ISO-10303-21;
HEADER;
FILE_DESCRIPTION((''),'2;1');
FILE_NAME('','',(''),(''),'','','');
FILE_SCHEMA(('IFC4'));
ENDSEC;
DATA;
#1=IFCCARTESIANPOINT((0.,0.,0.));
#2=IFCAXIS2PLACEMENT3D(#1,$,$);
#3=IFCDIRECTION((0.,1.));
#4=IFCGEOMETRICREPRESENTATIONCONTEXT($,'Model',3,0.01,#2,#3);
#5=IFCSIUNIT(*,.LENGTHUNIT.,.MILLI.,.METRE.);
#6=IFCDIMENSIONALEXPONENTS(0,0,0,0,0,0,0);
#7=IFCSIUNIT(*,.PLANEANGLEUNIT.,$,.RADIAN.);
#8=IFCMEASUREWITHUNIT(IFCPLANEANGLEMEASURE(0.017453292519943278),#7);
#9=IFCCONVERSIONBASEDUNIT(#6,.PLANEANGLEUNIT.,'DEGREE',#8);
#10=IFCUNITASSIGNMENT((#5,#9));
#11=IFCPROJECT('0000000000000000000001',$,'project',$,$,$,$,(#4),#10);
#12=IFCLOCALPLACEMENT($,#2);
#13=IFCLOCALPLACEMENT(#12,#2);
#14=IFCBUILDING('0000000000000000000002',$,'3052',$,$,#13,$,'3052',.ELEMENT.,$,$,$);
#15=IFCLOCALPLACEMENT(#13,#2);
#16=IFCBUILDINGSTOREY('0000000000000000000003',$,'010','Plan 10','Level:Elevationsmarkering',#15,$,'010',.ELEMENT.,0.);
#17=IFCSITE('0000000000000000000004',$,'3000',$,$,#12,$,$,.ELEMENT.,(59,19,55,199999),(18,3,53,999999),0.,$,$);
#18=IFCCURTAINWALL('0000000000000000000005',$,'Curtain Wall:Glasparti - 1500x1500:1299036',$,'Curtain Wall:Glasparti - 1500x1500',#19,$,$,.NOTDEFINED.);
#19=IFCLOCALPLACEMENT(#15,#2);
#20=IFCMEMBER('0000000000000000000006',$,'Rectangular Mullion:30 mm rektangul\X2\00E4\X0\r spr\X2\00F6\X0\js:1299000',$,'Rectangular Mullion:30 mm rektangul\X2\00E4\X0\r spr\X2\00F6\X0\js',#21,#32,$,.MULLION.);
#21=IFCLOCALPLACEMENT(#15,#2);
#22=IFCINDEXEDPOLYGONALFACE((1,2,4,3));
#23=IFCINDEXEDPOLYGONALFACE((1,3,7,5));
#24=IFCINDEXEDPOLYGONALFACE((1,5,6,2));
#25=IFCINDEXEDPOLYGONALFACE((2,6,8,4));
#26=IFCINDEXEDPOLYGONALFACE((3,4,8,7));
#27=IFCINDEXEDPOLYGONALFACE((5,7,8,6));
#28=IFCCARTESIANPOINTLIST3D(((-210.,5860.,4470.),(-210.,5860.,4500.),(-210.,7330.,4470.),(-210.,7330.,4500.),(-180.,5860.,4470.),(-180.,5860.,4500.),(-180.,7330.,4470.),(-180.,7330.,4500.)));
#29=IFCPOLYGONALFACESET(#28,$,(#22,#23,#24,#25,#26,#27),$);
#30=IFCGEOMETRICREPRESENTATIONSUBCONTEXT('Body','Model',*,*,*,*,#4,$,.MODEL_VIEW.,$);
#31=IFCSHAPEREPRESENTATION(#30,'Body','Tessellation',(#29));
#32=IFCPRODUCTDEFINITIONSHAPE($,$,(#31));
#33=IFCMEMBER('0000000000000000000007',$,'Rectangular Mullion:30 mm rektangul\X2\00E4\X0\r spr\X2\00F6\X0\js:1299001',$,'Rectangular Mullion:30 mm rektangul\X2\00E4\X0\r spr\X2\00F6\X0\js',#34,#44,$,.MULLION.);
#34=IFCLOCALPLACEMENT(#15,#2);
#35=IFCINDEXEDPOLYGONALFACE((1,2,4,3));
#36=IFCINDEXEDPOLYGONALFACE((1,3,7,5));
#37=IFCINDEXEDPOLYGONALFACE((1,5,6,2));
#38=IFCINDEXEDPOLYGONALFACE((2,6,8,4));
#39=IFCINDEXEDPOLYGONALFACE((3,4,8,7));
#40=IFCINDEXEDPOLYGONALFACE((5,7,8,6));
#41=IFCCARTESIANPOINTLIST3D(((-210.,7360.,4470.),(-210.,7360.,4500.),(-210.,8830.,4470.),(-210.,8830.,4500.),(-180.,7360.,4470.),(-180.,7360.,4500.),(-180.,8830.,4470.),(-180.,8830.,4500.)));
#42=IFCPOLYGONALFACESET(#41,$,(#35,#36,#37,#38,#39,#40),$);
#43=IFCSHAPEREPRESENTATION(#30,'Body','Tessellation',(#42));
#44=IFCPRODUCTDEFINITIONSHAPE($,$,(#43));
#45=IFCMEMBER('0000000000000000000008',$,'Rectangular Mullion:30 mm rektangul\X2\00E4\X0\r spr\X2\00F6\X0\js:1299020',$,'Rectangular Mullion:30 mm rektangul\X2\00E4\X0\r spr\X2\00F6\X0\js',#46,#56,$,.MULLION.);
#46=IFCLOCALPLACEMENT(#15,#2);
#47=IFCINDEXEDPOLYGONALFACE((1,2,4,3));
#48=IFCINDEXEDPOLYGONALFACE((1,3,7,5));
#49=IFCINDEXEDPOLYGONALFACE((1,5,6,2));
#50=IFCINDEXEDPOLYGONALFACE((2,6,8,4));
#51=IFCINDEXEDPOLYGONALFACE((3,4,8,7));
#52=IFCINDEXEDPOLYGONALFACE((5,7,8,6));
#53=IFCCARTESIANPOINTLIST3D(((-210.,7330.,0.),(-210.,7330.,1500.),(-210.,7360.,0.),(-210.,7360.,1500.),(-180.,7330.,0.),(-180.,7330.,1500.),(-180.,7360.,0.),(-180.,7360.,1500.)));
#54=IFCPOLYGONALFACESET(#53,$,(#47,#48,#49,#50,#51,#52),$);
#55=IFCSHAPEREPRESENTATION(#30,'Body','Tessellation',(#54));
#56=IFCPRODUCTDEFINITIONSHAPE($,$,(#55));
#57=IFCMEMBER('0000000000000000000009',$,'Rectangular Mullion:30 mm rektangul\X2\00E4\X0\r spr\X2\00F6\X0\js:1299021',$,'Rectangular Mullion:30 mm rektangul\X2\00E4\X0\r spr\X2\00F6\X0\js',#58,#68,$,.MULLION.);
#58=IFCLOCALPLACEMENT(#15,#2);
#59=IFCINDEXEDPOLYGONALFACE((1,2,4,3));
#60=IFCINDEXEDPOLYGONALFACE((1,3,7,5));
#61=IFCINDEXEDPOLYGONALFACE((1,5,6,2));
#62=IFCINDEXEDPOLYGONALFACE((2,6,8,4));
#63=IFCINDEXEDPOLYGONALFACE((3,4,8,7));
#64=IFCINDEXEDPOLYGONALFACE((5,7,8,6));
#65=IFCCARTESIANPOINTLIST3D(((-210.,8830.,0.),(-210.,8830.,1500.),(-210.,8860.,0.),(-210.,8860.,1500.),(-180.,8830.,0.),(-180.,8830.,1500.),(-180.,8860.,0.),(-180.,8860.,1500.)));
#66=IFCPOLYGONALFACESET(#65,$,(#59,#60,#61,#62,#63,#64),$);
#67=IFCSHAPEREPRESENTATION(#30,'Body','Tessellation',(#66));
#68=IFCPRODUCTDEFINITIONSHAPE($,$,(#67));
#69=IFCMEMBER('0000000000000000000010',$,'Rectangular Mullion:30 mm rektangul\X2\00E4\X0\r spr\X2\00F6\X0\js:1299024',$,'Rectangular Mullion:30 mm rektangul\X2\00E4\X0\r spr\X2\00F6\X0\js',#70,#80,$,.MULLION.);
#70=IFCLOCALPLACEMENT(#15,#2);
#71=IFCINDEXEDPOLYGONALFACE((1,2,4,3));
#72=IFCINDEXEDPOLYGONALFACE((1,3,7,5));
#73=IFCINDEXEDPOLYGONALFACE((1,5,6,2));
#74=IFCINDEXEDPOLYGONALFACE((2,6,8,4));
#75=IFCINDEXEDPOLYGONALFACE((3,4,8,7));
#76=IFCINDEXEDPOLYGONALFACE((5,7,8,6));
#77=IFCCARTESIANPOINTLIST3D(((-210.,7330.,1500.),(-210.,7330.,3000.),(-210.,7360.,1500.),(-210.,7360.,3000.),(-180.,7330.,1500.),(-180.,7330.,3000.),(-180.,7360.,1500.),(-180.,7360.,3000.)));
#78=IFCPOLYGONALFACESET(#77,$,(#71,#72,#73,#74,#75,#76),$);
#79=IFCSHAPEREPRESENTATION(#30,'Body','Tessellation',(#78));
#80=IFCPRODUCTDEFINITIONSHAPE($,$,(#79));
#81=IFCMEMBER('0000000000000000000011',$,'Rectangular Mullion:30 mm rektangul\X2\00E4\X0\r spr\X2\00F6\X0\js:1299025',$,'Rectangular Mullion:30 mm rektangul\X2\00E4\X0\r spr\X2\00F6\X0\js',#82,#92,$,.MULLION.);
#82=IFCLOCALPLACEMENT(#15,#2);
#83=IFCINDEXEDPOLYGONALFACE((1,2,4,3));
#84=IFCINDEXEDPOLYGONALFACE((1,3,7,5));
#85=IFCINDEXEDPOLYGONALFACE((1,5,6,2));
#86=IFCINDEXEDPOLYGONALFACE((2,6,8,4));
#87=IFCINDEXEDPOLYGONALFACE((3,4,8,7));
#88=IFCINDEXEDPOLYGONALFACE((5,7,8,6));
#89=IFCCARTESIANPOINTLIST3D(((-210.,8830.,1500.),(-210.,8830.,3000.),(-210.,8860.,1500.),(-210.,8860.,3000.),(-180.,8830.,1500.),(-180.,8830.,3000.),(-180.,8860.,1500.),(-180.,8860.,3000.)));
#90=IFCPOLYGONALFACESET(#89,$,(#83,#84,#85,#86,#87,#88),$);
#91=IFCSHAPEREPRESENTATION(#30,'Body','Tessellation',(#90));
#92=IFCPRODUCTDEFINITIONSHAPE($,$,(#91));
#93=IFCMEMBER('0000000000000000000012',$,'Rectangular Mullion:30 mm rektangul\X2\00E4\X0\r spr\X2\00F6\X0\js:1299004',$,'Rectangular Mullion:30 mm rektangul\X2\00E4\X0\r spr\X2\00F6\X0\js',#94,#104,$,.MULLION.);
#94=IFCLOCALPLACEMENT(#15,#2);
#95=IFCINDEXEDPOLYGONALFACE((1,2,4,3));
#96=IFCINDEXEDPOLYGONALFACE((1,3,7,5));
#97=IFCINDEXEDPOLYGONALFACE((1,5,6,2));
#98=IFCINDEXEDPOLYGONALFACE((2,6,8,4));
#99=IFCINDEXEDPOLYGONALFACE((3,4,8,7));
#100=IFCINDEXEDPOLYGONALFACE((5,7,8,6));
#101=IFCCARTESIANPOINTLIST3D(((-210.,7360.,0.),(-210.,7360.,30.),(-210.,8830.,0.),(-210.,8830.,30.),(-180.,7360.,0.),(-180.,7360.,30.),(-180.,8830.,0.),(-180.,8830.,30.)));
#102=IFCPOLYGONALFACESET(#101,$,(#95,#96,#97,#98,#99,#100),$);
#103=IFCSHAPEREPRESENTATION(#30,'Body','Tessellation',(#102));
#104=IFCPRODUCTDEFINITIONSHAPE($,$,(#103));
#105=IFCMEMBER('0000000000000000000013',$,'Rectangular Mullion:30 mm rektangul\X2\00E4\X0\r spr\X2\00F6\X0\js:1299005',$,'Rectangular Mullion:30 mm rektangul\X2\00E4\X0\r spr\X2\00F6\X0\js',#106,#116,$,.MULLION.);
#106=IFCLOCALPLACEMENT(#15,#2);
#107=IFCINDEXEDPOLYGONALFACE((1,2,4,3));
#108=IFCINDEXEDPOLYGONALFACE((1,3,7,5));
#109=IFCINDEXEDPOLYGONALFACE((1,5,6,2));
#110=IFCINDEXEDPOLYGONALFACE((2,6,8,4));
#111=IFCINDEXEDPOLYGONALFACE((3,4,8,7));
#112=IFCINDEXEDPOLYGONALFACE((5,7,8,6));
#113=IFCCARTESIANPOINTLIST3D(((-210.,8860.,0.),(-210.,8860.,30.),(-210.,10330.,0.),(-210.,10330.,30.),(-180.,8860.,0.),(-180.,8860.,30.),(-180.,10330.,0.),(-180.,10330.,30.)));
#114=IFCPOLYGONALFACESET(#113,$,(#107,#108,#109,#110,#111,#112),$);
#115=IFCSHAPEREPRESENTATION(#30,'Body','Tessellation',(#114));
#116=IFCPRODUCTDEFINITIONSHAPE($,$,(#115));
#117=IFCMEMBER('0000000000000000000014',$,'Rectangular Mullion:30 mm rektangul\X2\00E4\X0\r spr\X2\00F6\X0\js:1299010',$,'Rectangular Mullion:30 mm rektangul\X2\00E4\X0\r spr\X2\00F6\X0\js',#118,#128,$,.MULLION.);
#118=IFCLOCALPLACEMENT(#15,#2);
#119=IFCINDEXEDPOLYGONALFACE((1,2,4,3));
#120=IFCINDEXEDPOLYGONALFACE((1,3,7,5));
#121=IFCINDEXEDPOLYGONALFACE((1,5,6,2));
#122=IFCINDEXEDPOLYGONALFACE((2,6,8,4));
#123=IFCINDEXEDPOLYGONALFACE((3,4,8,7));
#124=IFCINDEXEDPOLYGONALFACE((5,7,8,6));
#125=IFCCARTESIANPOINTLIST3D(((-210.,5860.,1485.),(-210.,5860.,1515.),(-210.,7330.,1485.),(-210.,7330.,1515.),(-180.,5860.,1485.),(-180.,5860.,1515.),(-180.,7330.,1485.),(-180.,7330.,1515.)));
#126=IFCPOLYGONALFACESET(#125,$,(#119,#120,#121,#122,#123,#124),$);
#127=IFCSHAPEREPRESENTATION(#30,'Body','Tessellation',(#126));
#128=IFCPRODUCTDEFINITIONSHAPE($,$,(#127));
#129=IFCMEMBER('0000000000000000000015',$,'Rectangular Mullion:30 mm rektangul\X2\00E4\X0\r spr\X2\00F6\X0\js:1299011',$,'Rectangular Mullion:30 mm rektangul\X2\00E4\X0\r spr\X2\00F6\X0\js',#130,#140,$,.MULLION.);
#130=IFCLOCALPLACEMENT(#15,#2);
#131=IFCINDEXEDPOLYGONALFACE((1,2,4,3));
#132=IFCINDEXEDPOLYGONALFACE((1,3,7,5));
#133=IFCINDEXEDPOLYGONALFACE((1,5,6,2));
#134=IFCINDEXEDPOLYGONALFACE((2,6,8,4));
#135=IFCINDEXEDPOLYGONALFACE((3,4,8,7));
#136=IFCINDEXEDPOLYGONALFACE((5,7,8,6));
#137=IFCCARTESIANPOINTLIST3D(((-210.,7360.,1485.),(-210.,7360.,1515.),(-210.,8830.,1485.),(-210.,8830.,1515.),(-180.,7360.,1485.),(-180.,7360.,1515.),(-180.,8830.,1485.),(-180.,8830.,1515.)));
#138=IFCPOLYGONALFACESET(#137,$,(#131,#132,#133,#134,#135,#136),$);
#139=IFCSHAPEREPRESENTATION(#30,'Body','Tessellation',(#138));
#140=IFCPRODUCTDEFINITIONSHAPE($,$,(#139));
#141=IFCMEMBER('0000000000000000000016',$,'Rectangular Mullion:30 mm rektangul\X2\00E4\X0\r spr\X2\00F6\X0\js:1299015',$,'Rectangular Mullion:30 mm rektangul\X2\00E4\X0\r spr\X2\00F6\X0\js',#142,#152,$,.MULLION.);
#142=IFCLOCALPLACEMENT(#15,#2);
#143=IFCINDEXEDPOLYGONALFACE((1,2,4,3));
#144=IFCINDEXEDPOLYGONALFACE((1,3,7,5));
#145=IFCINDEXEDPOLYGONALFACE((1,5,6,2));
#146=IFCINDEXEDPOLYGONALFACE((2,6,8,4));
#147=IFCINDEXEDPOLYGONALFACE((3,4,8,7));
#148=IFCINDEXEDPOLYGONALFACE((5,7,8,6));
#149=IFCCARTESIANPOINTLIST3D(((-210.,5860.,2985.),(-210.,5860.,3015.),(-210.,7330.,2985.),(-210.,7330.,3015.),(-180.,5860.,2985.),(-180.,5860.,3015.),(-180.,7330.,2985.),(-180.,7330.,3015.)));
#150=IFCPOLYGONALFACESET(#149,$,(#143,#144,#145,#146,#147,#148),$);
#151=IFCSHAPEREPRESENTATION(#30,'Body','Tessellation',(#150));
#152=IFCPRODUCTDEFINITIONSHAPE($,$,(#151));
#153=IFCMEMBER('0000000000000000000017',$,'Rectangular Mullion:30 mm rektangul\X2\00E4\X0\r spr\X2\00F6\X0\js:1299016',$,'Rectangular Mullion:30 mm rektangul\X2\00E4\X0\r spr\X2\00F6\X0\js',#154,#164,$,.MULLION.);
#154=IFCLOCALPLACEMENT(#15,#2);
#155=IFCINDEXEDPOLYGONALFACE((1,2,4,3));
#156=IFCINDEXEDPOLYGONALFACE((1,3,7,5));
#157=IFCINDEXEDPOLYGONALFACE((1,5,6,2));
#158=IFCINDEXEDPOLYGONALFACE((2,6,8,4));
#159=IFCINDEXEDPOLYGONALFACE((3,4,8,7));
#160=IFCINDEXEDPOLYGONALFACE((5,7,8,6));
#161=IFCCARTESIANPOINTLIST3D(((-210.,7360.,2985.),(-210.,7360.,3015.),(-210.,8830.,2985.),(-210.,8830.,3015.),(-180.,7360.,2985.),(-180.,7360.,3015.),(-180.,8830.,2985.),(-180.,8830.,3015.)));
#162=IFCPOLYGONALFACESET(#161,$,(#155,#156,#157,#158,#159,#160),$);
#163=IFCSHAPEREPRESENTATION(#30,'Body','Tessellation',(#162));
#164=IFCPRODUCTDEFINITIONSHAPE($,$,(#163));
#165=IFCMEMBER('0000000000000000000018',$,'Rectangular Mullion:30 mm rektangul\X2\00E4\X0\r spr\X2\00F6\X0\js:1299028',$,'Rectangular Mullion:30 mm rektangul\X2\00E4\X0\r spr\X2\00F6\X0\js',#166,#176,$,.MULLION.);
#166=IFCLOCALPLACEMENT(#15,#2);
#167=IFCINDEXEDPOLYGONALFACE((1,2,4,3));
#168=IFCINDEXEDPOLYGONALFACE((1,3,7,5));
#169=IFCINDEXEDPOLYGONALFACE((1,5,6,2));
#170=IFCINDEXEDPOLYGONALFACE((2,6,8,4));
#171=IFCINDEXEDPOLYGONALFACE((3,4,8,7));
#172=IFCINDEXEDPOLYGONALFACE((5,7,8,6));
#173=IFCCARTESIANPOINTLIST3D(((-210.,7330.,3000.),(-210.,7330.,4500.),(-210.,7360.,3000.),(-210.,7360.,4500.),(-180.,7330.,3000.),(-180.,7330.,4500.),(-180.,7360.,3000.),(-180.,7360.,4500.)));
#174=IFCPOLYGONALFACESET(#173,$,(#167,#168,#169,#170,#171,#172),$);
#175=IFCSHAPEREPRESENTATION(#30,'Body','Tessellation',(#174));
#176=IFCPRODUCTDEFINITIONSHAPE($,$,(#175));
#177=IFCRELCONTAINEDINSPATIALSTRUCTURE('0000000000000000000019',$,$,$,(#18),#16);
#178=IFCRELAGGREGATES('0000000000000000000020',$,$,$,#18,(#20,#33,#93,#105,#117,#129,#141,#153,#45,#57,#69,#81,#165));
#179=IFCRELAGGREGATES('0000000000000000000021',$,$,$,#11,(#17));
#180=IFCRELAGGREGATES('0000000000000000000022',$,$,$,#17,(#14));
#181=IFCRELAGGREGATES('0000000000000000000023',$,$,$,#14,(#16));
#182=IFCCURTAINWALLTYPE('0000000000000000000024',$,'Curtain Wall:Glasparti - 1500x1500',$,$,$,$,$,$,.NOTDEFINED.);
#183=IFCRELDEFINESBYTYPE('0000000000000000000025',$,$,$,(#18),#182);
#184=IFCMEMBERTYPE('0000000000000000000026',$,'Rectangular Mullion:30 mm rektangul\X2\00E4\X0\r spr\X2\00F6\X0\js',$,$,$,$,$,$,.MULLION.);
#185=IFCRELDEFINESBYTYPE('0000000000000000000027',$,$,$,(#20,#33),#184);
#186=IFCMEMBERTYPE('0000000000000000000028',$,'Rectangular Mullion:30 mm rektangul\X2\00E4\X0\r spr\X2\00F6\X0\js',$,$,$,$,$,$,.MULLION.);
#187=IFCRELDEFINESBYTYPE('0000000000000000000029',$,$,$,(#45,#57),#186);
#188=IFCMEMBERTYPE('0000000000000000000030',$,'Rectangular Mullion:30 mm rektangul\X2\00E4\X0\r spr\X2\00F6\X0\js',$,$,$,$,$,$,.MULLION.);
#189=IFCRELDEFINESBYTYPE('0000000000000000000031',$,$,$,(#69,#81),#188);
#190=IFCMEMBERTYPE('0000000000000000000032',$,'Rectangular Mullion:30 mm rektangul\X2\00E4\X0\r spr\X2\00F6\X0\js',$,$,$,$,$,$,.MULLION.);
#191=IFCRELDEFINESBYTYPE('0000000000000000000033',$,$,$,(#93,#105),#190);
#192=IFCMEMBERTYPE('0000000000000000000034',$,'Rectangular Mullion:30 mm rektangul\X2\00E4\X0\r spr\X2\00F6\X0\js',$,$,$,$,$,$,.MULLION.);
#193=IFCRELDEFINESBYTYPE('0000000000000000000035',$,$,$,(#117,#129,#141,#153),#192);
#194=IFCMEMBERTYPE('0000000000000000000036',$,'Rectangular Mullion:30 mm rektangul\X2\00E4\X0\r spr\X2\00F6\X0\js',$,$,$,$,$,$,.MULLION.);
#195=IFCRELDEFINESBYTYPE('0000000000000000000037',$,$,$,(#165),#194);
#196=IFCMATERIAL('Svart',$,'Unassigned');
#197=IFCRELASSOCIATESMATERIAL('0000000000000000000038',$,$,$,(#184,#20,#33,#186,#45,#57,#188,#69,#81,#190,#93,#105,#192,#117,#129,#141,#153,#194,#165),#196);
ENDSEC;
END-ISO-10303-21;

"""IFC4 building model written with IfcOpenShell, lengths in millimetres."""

from ifc_helpers import new_model, entity, si_unit, converted_unit, direction, frame, origin, place, context, subcontext, project, spatial, indexed_curve, outline, extrude, source, transform, mapped, material, type_object, type_shapes, element, aggregate, save


model = new_model("IFC4")

# Units and contexts
model_context = context("Model", 3, precision=0.01, world=origin(), true_north=direction((0.0, 1.0)))
body_context = subcontext(model_context, "Body", "Model", "MODEL_VIEW")
ifc_project = project(units=[si_unit("LENGTHUNIT", "METRE", prefix="MILLI"), converted_unit("PLANEANGLEUNIT", "DEGREE", entity("IfcPlaneAngleMeasure", 0.017453292519943278), si_unit("PLANEANGLEUNIT", "RADIAN"), dimensions=[0, 0, 0, 0, 0, 0, 0])], contexts=[model_context])

# Site, building, storey
site_placement = place(None, origin())
site = spatial("IfcSite", under=ifc_project, at=site_placement, Name="3000", CompositionType="ELEMENT", RefLatitude=(59, 19, 55, 199999), RefLongitude=(18, 3, 53, 999999), RefElevation=0.0)
building_placement = place(site_placement, origin())
building = spatial("IfcBuilding", under=site, at=building_placement, Name="3052", LongName="3052", CompositionType="ELEMENT")
storey_placement = place(building_placement, origin())
storey = spatial("IfcBuildingStorey", under=building, at=storey_placement, Name="010", Description="Plan 10", ObjectType="Level:Elevationsmarkering", LongName="010", CompositionType="ELEMENT", Elevation=0.0)

# Curtain wall, members
curtain_wall_type = type_object("IfcCurtainWallType", Name="Curtain Wall:Glasparti - 1500x1500", PredefinedType="NOTDEFINED")
curtain_wall_placement = place(storey_placement, origin())
curtain_wall = element("IfcCurtainWall", 1, at=curtain_wall_placement, inside=storey, type_object=curtain_wall_type, Name="Curtain Wall:Glasparti - 1500x1500:1299036", ObjectType="Curtain Wall:Glasparti - 1500x1500", PredefinedType="NOTDEFINED")
ifc_material_1 = material(Name="Svart", Category="Unassigned")
member_type_1 = type_object("IfcMemberType", Name="Rectangular Mullion:30 mm rektangulär spröjs", PredefinedType="MULLION", material=ifc_material_1)
shared_shape_1 = source(origin(), body_context, "Body", "SweptSolid", [
    extrude(outline(indexed_curve([(-15.0, -15.0), (15.0, -15.0), (15.0, 15.0), (-15.0, 15.0), (-15.0, -15.0)], self_intersect=False)), frame((-15.0, 0.0, -1470.0), z_axis=(0.0, 0.0, 1.0), x_axis=(-1.0, 0.0, 0.0)), (0.0, 0.0, 1.0), 1470.0),
])
type_shapes(member_type_1, [shared_shape_1])
member_1_placement = place(curtain_wall_placement, frame((-195.0, 7330.0, 4500.0), z_axis=(0.0, 1.0, 0.0), x_axis=(0.0, 0.0, 1.0)))
member_1 = element("IfcMember", 2, at=member_1_placement, type_object=member_type_1, material=ifc_material_1, Name="Rectangular Mullion:30 mm rektangulär spröjs:1299000", ObjectType="Rectangular Mullion:30 mm rektangulär spröjs", PredefinedType="MULLION", context=body_context, shape_type="MappedRepresentation", body=[
    mapped(shared_shape_1, transform((0.0, 0.0, 0.0), scale=1.0)),
])
member_2_placement = place(curtain_wall_placement, frame((-195.0, 8830.0, 4500.0), z_axis=(0.0, 1.0, 0.0), x_axis=(0.0, 0.0, 1.0)))
member_2 = element("IfcMember", 3, at=member_2_placement, type_object=member_type_1, material=ifc_material_1, Name="Rectangular Mullion:30 mm rektangulär spröjs:1299001", ObjectType="Rectangular Mullion:30 mm rektangulär spröjs", PredefinedType="MULLION", context=body_context, shape_type="MappedRepresentation", body=[
    mapped(shared_shape_1, transform((0.0, 0.0, 0.0), scale=1.0)),
])
member_type_2 = type_object("IfcMemberType", Name="Rectangular Mullion:30 mm rektangulär spröjs", PredefinedType="MULLION", material=ifc_material_1)
shared_shape_2 = source(origin(), body_context, "Body", "SweptSolid", [
    extrude(outline(indexed_curve([(-15.0, -15.0), (15.0, -15.0), (15.0, 15.0), (-15.0, 15.0), (-15.0, -15.0)], self_intersect=False)), frame((0.0, 0.0, -1500.0), z_axis=(0.0, 0.0, 1.0), x_axis=(-1.0, 0.0, 0.0)), (0.0, 0.0, 1.0), 1500.0),
])
type_shapes(member_type_2, [shared_shape_2])
member_3_placement = place(curtain_wall_placement, frame((-195.0, 7345.0, 0.0), z_axis=(0.0, 0.0, -1.0), x_axis=(0.0, 1.0, 0.0)))
member_3 = element("IfcMember", 4, at=member_3_placement, type_object=member_type_2, material=ifc_material_1, Name="Rectangular Mullion:30 mm rektangulär spröjs:1299020", ObjectType="Rectangular Mullion:30 mm rektangulär spröjs", PredefinedType="MULLION", context=body_context, shape_type="MappedRepresentation", body=[
    mapped(shared_shape_2, transform((0.0, 0.0, 0.0), scale=1.0)),
])
member_4_placement = place(curtain_wall_placement, frame((-195.0, 8845.0, 0.0), z_axis=(0.0, 0.0, -1.0), x_axis=(0.0, 1.0, 0.0)))
member_4 = element("IfcMember", 5, at=member_4_placement, type_object=member_type_2, material=ifc_material_1, Name="Rectangular Mullion:30 mm rektangulär spröjs:1299021", ObjectType="Rectangular Mullion:30 mm rektangulär spröjs", PredefinedType="MULLION", context=body_context, shape_type="MappedRepresentation", body=[
    mapped(shared_shape_2, transform((0.0, 0.0, 0.0), scale=1.0)),
])
member_type_3 = type_object("IfcMemberType", Name="Rectangular Mullion:30 mm rektangulär spröjs", PredefinedType="MULLION", material=ifc_material_1)
shared_shape_3 = source(origin(), body_context, "Body", "SweptSolid", [
    extrude(outline(indexed_curve([(-15.0, -15.0), (15.0, -15.0), (15.0, 15.0), (-15.0, 15.0), (-15.0, -15.0)], self_intersect=False)), frame((0.0, 0.0, -1500.0), z_axis=(0.0, 0.0, 1.0), x_axis=(-1.0, 0.0, 0.0)), (0.0, 0.0, 1.0), 1500.0),
])
type_shapes(member_type_3, [shared_shape_3])
member_5_placement = place(curtain_wall_placement, frame((-195.0, 7345.0, 1500.0), z_axis=(0.0, 0.0, -1.0), x_axis=(0.0, 1.0, 0.0)))
member_5 = element("IfcMember", 6, at=member_5_placement, type_object=member_type_3, material=ifc_material_1, Name="Rectangular Mullion:30 mm rektangulär spröjs:1299024", ObjectType="Rectangular Mullion:30 mm rektangulär spröjs", PredefinedType="MULLION", context=body_context, shape_type="MappedRepresentation", body=[
    mapped(shared_shape_3, transform((0.0, 0.0, 0.0), scale=1.0)),
])
member_6_placement = place(curtain_wall_placement, frame((-195.0, 8845.0, 1500.0), z_axis=(0.0, 0.0, -1.0), x_axis=(0.0, 1.0, 0.0)))
member_6 = element("IfcMember", 7, at=member_6_placement, type_object=member_type_3, material=ifc_material_1, Name="Rectangular Mullion:30 mm rektangulär spröjs:1299025", ObjectType="Rectangular Mullion:30 mm rektangulär spröjs", PredefinedType="MULLION", context=body_context, shape_type="MappedRepresentation", body=[
    mapped(shared_shape_3, transform((0.0, 0.0, 0.0), scale=1.0)),
])
member_type_4 = type_object("IfcMemberType", Name="Rectangular Mullion:30 mm rektangulär spröjs", PredefinedType="MULLION", material=ifc_material_1)
shared_shape_4 = source(origin(), body_context, "Body", "SweptSolid", [
    extrude(outline(indexed_curve([(-15.0, -15.0), (15.0, -15.0), (15.0, 15.0), (-15.0, 15.0), (-15.0, -15.0)], self_intersect=False)), frame((-15.0, 0.0, -1470.0), z_axis=(0.0, 0.0, 1.0), x_axis=(-1.0, 0.0, 0.0)), (0.0, 0.0, 1.0), 1470.0),
])
type_shapes(member_type_4, [shared_shape_4])
member_7_placement = place(curtain_wall_placement, frame((-195.0, 7360.0, 0.0), z_axis=(0.0, -1.0, 0.0), x_axis=(0.0, 0.0, -1.0)))
member_7 = element("IfcMember", 8, at=member_7_placement, type_object=member_type_4, material=ifc_material_1, Name="Rectangular Mullion:30 mm rektangulär spröjs:1299004", ObjectType="Rectangular Mullion:30 mm rektangulär spröjs", PredefinedType="MULLION", context=body_context, shape_type="MappedRepresentation", body=[
    mapped(shared_shape_4, transform((0.0, 0.0, 0.0), scale=1.0)),
])
member_8_placement = place(curtain_wall_placement, frame((-195.0, 8860.0, 0.0), z_axis=(0.0, -1.0, 0.0), x_axis=(0.0, 0.0, -1.0)))
member_8 = element("IfcMember", 9, at=member_8_placement, type_object=member_type_4, material=ifc_material_1, Name="Rectangular Mullion:30 mm rektangulär spröjs:1299005", ObjectType="Rectangular Mullion:30 mm rektangulär spröjs", PredefinedType="MULLION", context=body_context, shape_type="MappedRepresentation", body=[
    mapped(shared_shape_4, transform((0.0, 0.0, 0.0), scale=1.0)),
])
member_type_5 = type_object("IfcMemberType", Name="Rectangular Mullion:30 mm rektangulär spröjs", PredefinedType="MULLION", material=ifc_material_1)
shared_shape_5 = source(origin(), body_context, "Body", "SweptSolid", [
    extrude(outline(indexed_curve([(-15.0, -15.0), (15.0, -15.0), (15.0, 15.0), (-15.0, 15.0), (-15.0, -15.0)], self_intersect=False)), frame((0.0, 0.0, -1470.0), z_axis=(0.0, 0.0, 1.0), x_axis=(-1.0, 0.0, 0.0)), (0.0, 0.0, 1.0), 1470.0),
])
type_shapes(member_type_5, [shared_shape_5])
member_9_placement = place(curtain_wall_placement, frame((-195.0, 7330.0, 1500.0), z_axis=(0.0, 1.0, 0.0), x_axis=(0.0, 0.0, 1.0)))
member_9 = element("IfcMember", 10, at=member_9_placement, type_object=member_type_5, material=ifc_material_1, Name="Rectangular Mullion:30 mm rektangulär spröjs:1299010", ObjectType="Rectangular Mullion:30 mm rektangulär spröjs", PredefinedType="MULLION", context=body_context, shape_type="MappedRepresentation", body=[
    mapped(shared_shape_5, transform((0.0, 0.0, 0.0), scale=1.0)),
])
member_10_placement = place(curtain_wall_placement, frame((-195.0, 8830.0, 1500.0), z_axis=(0.0, 1.0, 0.0), x_axis=(0.0, 0.0, 1.0)))
member_10 = element("IfcMember", 11, at=member_10_placement, type_object=member_type_5, material=ifc_material_1, Name="Rectangular Mullion:30 mm rektangulär spröjs:1299011", ObjectType="Rectangular Mullion:30 mm rektangulär spröjs", PredefinedType="MULLION", context=body_context, shape_type="MappedRepresentation", body=[
    mapped(shared_shape_5, transform((0.0, 0.0, 0.0), scale=1.0)),
])
member_11_placement = place(curtain_wall_placement, frame((-195.0, 7330.0, 3000.0), z_axis=(0.0, 1.0, 0.0), x_axis=(0.0, 0.0, 1.0)))
member_11 = element("IfcMember", 12, at=member_11_placement, type_object=member_type_5, material=ifc_material_1, Name="Rectangular Mullion:30 mm rektangulär spröjs:1299015", ObjectType="Rectangular Mullion:30 mm rektangulär spröjs", PredefinedType="MULLION", context=body_context, shape_type="MappedRepresentation", body=[
    mapped(shared_shape_5, transform((0.0, 0.0, 0.0), scale=1.0)),
])
member_12_placement = place(curtain_wall_placement, frame((-195.0, 8830.0, 3000.0), z_axis=(0.0, 1.0, 0.0), x_axis=(0.0, 0.0, 1.0)))
member_12 = element("IfcMember", 13, at=member_12_placement, type_object=member_type_5, material=ifc_material_1, Name="Rectangular Mullion:30 mm rektangulär spröjs:1299016", ObjectType="Rectangular Mullion:30 mm rektangulär spröjs", PredefinedType="MULLION", context=body_context, shape_type="MappedRepresentation", body=[
    mapped(shared_shape_5, transform((0.0, 0.0, 0.0), scale=1.0)),
])
member_type_6 = type_object("IfcMemberType", Name="Rectangular Mullion:30 mm rektangulär spröjs", PredefinedType="MULLION", material=ifc_material_1)
shared_shape_6 = source(origin(), body_context, "Body", "SweptSolid", [
    extrude(outline(indexed_curve([(-15.0, -15.0), (15.0, -15.0), (15.0, 15.0), (-15.0, 15.0), (-15.0, -15.0)], self_intersect=False)), frame((0.0, 0.0, -1500.0), z_axis=(0.0, 0.0, 1.0), x_axis=(-1.0, 0.0, 0.0)), (0.0, 0.0, 1.0), 1500.0),
])
type_shapes(member_type_6, [shared_shape_6])
member_13_placement = place(curtain_wall_placement, frame((-195.0, 7345.0, 3000.0), z_axis=(0.0, 0.0, -1.0), x_axis=(0.0, 1.0, 0.0)))
member_13 = element("IfcMember", 14, at=member_13_placement, type_object=member_type_6, material=ifc_material_1, Name="Rectangular Mullion:30 mm rektangulär spröjs:1299028", ObjectType="Rectangular Mullion:30 mm rektangulär spröjs", PredefinedType="MULLION", context=body_context, shape_type="MappedRepresentation", body=[
    mapped(shared_shape_6, transform((0.0, 0.0, 0.0), scale=1.0)),
])
aggregate(curtain_wall, [member_1, member_2, member_7, member_8, member_9, member_10, member_11, member_12, member_3, member_4, member_5, member_6, member_13])

save(model, "model.ifc")
